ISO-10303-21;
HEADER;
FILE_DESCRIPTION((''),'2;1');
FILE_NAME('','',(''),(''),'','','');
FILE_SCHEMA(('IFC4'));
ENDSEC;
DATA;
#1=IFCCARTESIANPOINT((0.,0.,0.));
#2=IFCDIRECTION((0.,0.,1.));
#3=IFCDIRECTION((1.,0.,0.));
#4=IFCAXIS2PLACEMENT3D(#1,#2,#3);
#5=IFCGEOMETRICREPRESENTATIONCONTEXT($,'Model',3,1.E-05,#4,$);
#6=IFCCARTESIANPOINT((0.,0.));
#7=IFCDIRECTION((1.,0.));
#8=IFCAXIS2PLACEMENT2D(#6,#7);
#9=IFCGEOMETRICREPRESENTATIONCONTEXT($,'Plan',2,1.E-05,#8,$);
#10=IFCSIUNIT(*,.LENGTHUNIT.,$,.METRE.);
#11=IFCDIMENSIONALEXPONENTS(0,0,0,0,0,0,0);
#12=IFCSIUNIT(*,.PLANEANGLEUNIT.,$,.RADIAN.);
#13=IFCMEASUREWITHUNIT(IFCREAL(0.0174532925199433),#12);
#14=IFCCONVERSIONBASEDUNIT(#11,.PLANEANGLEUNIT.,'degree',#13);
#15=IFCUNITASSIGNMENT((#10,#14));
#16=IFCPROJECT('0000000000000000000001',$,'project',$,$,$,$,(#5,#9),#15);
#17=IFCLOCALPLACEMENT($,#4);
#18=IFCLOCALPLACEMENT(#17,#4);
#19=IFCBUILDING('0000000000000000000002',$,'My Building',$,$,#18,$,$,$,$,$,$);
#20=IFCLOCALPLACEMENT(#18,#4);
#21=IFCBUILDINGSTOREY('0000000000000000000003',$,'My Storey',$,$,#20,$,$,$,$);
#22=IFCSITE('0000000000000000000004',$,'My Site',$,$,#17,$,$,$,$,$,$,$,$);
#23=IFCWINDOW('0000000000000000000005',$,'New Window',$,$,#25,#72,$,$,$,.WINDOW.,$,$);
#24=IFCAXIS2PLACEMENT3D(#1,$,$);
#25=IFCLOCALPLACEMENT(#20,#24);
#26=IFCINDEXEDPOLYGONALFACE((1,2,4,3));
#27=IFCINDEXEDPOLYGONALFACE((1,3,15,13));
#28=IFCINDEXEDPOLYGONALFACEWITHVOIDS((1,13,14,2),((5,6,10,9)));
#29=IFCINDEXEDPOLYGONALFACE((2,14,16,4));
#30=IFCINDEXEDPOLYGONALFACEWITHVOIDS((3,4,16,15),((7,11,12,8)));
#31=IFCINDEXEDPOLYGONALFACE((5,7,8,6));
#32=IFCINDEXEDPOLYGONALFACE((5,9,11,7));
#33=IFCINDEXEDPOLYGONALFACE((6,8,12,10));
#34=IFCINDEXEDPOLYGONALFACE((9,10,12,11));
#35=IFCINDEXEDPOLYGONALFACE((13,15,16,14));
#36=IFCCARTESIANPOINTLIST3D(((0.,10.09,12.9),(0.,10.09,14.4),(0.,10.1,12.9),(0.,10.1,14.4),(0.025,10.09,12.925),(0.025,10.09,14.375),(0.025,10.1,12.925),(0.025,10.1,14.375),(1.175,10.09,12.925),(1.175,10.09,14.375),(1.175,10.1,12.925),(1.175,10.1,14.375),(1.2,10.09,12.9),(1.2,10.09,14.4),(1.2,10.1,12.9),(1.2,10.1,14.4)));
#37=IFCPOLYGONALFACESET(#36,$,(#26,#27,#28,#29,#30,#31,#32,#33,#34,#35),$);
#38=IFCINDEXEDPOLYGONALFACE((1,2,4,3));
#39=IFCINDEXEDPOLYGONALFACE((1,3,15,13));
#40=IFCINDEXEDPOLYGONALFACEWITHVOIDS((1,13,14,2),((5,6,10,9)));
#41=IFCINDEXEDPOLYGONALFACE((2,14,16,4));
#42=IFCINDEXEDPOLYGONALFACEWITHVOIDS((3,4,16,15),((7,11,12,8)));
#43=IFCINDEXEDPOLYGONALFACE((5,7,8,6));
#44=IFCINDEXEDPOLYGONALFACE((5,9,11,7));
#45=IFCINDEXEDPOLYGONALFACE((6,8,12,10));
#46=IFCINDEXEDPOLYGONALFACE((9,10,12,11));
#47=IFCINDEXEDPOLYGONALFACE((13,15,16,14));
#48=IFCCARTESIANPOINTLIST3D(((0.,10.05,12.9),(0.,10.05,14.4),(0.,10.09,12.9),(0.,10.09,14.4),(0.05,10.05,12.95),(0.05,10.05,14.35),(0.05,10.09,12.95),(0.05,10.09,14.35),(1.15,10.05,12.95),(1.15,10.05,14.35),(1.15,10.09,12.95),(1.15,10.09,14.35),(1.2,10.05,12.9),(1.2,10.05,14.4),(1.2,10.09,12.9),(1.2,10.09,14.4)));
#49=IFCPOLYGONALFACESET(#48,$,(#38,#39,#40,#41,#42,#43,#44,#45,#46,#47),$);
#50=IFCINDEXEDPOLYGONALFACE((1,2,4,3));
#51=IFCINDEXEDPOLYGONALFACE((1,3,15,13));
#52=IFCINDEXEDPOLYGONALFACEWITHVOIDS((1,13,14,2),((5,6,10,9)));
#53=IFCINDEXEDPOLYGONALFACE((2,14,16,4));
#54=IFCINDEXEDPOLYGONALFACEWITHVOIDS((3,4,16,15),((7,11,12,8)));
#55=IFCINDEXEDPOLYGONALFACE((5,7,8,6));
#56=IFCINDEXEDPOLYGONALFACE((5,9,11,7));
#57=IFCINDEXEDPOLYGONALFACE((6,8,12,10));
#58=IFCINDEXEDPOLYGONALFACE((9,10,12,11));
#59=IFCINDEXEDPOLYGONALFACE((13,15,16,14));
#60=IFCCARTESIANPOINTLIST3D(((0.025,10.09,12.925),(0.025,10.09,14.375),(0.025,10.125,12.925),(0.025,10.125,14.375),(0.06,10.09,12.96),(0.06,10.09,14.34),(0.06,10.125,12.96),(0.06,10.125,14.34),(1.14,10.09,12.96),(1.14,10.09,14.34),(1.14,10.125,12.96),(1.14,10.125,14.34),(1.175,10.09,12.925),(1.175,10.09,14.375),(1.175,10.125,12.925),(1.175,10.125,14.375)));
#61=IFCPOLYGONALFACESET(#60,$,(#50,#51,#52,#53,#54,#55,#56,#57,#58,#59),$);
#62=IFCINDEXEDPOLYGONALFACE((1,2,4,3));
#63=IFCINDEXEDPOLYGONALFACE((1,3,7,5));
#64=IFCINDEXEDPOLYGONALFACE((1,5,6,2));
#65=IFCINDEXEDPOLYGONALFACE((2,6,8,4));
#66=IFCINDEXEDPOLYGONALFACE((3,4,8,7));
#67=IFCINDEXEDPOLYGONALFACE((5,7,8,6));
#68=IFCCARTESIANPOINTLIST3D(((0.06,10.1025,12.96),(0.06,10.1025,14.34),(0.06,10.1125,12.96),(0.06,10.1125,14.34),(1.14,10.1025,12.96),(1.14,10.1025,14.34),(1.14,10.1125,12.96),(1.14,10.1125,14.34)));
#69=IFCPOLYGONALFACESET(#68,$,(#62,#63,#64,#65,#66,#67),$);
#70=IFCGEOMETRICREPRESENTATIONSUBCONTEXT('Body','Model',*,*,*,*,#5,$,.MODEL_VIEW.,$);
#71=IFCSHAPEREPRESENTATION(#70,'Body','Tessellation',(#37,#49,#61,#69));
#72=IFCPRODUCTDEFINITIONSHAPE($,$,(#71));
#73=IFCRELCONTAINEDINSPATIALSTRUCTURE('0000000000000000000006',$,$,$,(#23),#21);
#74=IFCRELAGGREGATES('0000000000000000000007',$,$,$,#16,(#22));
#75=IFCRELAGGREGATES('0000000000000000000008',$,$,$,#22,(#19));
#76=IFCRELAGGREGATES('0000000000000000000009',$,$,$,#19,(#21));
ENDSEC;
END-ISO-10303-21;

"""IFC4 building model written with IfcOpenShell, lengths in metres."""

from ifc_helpers import new_model, entity, si_unit, converted_unit, frame, origin_with_axes, origin_2d_with_axis, place, context, subcontext, project, spatial, line, indexed_curve, outline, extrude, element, save


model = new_model("IFC4")

# Units and contexts
model_context = context("Model", 3, precision=1e-05, world=origin_with_axes())
plan_context = context("Plan", 2, precision=1e-05, world=origin_2d_with_axis())
body_context = subcontext(model_context, "Body", "Model", "MODEL_VIEW")
ifc_project = project(units=[si_unit("LENGTHUNIT", "METRE"), converted_unit("PLANEANGLEUNIT", "degree", entity("IfcReal", 0.0174532925199433), si_unit("PLANEANGLEUNIT", "RADIAN"), dimensions=[0, 0, 0, 0, 0, 0, 0])], contexts=[model_context, plan_context])

# Site, building, storey
site_placement = place(None, origin_with_axes())
site = spatial("IfcSite", under=ifc_project, at=site_placement, Name="My Site")
building_placement = place(site_placement, origin_with_axes())
building = spatial("IfcBuilding", under=site, at=building_placement, Name="My Building")
storey_placement = place(building_placement, origin_with_axes())
storey = spatial("IfcBuildingStorey", under=building, at=storey_placement, Name="My Storey")

# Window
for number, where, z_axis, x_axis, name in (
    (1, (0.0, 10.0, 12.9), (0.0, 0.0, 1.0), (1.0, 0.0, 0.0), "New Window"),
):
    element("IfcWindow", number, at=place(storey_placement, frame(where, z_axis=z_axis, x_axis=x_axis)), inside=storey, Name=name, PredefinedType="WINDOW", context=body_context, shape_type="SweptSolid", body=[
        extrude(outline(indexed_curve([(0.0, 0.0), (1.2, 0.0), (1.2, 1.5), (0.0, 1.5)], segments=[line(1, 2, 3, 4, 1)]), holes=[indexed_curve([(0.025, 0.025), (1.175, 0.025), (1.175, 1.475), (0.025, 1.475)], segments=[line(1, 2, 3, 4, 1)])]), frame((0.0, 0.09, 0.0), z_axis=(0.0, -1.0, 0.0), x_axis=(1.0, 0.0, 0.0)), (0.0, 0.0, -1.0), 0.01),
        extrude(outline(indexed_curve([(0.0, 0.0), (1.2, 0.0), (1.2, 1.5), (0.0, 1.5)], segments=[line(1, 2, 3, 4, 1)]), holes=[indexed_curve([(0.05, 0.05), (1.15, 0.05), (1.15, 1.45), (0.05, 1.45)], segments=[line(1, 2, 3, 4, 1)])]), frame((0.0, 0.05, 0.0), z_axis=(0.0, -1.0, 0.0), x_axis=(1.0, 0.0, 0.0)), (0.0, 0.0, -1.0), 0.04),
        extrude(outline(indexed_curve([(0.0, 0.0), (1.15, 0.0), (1.15, 1.45), (0.0, 1.45)], segments=[line(1, 2, 3, 4, 1)]), holes=[indexed_curve([(0.035, 0.035), (1.115, 0.035), (1.115, 1.415), (0.035, 1.415)], segments=[line(1, 2, 3, 4, 1)])]), frame((0.025, 0.09, 0.025), z_axis=(0.0, -1.0, 0.0), x_axis=(1.0, 0.0, 0.0)), (0.0, 0.0, -1.0), 0.035),
        extrude(outline(indexed_curve([(0.035, 0.035), (1.115, 0.035), (1.115, 1.415), (0.035, 1.415)], segments=[line(1, 2, 3, 4, 1)])), frame((0.025, 0.1025, 0.025), z_axis=(0.0, -1.0, 0.0), x_axis=(1.0, 0.0, 0.0)), (0.0, 0.0, -1.0), 0.01),
    ])

save(model, "model.ifc")
